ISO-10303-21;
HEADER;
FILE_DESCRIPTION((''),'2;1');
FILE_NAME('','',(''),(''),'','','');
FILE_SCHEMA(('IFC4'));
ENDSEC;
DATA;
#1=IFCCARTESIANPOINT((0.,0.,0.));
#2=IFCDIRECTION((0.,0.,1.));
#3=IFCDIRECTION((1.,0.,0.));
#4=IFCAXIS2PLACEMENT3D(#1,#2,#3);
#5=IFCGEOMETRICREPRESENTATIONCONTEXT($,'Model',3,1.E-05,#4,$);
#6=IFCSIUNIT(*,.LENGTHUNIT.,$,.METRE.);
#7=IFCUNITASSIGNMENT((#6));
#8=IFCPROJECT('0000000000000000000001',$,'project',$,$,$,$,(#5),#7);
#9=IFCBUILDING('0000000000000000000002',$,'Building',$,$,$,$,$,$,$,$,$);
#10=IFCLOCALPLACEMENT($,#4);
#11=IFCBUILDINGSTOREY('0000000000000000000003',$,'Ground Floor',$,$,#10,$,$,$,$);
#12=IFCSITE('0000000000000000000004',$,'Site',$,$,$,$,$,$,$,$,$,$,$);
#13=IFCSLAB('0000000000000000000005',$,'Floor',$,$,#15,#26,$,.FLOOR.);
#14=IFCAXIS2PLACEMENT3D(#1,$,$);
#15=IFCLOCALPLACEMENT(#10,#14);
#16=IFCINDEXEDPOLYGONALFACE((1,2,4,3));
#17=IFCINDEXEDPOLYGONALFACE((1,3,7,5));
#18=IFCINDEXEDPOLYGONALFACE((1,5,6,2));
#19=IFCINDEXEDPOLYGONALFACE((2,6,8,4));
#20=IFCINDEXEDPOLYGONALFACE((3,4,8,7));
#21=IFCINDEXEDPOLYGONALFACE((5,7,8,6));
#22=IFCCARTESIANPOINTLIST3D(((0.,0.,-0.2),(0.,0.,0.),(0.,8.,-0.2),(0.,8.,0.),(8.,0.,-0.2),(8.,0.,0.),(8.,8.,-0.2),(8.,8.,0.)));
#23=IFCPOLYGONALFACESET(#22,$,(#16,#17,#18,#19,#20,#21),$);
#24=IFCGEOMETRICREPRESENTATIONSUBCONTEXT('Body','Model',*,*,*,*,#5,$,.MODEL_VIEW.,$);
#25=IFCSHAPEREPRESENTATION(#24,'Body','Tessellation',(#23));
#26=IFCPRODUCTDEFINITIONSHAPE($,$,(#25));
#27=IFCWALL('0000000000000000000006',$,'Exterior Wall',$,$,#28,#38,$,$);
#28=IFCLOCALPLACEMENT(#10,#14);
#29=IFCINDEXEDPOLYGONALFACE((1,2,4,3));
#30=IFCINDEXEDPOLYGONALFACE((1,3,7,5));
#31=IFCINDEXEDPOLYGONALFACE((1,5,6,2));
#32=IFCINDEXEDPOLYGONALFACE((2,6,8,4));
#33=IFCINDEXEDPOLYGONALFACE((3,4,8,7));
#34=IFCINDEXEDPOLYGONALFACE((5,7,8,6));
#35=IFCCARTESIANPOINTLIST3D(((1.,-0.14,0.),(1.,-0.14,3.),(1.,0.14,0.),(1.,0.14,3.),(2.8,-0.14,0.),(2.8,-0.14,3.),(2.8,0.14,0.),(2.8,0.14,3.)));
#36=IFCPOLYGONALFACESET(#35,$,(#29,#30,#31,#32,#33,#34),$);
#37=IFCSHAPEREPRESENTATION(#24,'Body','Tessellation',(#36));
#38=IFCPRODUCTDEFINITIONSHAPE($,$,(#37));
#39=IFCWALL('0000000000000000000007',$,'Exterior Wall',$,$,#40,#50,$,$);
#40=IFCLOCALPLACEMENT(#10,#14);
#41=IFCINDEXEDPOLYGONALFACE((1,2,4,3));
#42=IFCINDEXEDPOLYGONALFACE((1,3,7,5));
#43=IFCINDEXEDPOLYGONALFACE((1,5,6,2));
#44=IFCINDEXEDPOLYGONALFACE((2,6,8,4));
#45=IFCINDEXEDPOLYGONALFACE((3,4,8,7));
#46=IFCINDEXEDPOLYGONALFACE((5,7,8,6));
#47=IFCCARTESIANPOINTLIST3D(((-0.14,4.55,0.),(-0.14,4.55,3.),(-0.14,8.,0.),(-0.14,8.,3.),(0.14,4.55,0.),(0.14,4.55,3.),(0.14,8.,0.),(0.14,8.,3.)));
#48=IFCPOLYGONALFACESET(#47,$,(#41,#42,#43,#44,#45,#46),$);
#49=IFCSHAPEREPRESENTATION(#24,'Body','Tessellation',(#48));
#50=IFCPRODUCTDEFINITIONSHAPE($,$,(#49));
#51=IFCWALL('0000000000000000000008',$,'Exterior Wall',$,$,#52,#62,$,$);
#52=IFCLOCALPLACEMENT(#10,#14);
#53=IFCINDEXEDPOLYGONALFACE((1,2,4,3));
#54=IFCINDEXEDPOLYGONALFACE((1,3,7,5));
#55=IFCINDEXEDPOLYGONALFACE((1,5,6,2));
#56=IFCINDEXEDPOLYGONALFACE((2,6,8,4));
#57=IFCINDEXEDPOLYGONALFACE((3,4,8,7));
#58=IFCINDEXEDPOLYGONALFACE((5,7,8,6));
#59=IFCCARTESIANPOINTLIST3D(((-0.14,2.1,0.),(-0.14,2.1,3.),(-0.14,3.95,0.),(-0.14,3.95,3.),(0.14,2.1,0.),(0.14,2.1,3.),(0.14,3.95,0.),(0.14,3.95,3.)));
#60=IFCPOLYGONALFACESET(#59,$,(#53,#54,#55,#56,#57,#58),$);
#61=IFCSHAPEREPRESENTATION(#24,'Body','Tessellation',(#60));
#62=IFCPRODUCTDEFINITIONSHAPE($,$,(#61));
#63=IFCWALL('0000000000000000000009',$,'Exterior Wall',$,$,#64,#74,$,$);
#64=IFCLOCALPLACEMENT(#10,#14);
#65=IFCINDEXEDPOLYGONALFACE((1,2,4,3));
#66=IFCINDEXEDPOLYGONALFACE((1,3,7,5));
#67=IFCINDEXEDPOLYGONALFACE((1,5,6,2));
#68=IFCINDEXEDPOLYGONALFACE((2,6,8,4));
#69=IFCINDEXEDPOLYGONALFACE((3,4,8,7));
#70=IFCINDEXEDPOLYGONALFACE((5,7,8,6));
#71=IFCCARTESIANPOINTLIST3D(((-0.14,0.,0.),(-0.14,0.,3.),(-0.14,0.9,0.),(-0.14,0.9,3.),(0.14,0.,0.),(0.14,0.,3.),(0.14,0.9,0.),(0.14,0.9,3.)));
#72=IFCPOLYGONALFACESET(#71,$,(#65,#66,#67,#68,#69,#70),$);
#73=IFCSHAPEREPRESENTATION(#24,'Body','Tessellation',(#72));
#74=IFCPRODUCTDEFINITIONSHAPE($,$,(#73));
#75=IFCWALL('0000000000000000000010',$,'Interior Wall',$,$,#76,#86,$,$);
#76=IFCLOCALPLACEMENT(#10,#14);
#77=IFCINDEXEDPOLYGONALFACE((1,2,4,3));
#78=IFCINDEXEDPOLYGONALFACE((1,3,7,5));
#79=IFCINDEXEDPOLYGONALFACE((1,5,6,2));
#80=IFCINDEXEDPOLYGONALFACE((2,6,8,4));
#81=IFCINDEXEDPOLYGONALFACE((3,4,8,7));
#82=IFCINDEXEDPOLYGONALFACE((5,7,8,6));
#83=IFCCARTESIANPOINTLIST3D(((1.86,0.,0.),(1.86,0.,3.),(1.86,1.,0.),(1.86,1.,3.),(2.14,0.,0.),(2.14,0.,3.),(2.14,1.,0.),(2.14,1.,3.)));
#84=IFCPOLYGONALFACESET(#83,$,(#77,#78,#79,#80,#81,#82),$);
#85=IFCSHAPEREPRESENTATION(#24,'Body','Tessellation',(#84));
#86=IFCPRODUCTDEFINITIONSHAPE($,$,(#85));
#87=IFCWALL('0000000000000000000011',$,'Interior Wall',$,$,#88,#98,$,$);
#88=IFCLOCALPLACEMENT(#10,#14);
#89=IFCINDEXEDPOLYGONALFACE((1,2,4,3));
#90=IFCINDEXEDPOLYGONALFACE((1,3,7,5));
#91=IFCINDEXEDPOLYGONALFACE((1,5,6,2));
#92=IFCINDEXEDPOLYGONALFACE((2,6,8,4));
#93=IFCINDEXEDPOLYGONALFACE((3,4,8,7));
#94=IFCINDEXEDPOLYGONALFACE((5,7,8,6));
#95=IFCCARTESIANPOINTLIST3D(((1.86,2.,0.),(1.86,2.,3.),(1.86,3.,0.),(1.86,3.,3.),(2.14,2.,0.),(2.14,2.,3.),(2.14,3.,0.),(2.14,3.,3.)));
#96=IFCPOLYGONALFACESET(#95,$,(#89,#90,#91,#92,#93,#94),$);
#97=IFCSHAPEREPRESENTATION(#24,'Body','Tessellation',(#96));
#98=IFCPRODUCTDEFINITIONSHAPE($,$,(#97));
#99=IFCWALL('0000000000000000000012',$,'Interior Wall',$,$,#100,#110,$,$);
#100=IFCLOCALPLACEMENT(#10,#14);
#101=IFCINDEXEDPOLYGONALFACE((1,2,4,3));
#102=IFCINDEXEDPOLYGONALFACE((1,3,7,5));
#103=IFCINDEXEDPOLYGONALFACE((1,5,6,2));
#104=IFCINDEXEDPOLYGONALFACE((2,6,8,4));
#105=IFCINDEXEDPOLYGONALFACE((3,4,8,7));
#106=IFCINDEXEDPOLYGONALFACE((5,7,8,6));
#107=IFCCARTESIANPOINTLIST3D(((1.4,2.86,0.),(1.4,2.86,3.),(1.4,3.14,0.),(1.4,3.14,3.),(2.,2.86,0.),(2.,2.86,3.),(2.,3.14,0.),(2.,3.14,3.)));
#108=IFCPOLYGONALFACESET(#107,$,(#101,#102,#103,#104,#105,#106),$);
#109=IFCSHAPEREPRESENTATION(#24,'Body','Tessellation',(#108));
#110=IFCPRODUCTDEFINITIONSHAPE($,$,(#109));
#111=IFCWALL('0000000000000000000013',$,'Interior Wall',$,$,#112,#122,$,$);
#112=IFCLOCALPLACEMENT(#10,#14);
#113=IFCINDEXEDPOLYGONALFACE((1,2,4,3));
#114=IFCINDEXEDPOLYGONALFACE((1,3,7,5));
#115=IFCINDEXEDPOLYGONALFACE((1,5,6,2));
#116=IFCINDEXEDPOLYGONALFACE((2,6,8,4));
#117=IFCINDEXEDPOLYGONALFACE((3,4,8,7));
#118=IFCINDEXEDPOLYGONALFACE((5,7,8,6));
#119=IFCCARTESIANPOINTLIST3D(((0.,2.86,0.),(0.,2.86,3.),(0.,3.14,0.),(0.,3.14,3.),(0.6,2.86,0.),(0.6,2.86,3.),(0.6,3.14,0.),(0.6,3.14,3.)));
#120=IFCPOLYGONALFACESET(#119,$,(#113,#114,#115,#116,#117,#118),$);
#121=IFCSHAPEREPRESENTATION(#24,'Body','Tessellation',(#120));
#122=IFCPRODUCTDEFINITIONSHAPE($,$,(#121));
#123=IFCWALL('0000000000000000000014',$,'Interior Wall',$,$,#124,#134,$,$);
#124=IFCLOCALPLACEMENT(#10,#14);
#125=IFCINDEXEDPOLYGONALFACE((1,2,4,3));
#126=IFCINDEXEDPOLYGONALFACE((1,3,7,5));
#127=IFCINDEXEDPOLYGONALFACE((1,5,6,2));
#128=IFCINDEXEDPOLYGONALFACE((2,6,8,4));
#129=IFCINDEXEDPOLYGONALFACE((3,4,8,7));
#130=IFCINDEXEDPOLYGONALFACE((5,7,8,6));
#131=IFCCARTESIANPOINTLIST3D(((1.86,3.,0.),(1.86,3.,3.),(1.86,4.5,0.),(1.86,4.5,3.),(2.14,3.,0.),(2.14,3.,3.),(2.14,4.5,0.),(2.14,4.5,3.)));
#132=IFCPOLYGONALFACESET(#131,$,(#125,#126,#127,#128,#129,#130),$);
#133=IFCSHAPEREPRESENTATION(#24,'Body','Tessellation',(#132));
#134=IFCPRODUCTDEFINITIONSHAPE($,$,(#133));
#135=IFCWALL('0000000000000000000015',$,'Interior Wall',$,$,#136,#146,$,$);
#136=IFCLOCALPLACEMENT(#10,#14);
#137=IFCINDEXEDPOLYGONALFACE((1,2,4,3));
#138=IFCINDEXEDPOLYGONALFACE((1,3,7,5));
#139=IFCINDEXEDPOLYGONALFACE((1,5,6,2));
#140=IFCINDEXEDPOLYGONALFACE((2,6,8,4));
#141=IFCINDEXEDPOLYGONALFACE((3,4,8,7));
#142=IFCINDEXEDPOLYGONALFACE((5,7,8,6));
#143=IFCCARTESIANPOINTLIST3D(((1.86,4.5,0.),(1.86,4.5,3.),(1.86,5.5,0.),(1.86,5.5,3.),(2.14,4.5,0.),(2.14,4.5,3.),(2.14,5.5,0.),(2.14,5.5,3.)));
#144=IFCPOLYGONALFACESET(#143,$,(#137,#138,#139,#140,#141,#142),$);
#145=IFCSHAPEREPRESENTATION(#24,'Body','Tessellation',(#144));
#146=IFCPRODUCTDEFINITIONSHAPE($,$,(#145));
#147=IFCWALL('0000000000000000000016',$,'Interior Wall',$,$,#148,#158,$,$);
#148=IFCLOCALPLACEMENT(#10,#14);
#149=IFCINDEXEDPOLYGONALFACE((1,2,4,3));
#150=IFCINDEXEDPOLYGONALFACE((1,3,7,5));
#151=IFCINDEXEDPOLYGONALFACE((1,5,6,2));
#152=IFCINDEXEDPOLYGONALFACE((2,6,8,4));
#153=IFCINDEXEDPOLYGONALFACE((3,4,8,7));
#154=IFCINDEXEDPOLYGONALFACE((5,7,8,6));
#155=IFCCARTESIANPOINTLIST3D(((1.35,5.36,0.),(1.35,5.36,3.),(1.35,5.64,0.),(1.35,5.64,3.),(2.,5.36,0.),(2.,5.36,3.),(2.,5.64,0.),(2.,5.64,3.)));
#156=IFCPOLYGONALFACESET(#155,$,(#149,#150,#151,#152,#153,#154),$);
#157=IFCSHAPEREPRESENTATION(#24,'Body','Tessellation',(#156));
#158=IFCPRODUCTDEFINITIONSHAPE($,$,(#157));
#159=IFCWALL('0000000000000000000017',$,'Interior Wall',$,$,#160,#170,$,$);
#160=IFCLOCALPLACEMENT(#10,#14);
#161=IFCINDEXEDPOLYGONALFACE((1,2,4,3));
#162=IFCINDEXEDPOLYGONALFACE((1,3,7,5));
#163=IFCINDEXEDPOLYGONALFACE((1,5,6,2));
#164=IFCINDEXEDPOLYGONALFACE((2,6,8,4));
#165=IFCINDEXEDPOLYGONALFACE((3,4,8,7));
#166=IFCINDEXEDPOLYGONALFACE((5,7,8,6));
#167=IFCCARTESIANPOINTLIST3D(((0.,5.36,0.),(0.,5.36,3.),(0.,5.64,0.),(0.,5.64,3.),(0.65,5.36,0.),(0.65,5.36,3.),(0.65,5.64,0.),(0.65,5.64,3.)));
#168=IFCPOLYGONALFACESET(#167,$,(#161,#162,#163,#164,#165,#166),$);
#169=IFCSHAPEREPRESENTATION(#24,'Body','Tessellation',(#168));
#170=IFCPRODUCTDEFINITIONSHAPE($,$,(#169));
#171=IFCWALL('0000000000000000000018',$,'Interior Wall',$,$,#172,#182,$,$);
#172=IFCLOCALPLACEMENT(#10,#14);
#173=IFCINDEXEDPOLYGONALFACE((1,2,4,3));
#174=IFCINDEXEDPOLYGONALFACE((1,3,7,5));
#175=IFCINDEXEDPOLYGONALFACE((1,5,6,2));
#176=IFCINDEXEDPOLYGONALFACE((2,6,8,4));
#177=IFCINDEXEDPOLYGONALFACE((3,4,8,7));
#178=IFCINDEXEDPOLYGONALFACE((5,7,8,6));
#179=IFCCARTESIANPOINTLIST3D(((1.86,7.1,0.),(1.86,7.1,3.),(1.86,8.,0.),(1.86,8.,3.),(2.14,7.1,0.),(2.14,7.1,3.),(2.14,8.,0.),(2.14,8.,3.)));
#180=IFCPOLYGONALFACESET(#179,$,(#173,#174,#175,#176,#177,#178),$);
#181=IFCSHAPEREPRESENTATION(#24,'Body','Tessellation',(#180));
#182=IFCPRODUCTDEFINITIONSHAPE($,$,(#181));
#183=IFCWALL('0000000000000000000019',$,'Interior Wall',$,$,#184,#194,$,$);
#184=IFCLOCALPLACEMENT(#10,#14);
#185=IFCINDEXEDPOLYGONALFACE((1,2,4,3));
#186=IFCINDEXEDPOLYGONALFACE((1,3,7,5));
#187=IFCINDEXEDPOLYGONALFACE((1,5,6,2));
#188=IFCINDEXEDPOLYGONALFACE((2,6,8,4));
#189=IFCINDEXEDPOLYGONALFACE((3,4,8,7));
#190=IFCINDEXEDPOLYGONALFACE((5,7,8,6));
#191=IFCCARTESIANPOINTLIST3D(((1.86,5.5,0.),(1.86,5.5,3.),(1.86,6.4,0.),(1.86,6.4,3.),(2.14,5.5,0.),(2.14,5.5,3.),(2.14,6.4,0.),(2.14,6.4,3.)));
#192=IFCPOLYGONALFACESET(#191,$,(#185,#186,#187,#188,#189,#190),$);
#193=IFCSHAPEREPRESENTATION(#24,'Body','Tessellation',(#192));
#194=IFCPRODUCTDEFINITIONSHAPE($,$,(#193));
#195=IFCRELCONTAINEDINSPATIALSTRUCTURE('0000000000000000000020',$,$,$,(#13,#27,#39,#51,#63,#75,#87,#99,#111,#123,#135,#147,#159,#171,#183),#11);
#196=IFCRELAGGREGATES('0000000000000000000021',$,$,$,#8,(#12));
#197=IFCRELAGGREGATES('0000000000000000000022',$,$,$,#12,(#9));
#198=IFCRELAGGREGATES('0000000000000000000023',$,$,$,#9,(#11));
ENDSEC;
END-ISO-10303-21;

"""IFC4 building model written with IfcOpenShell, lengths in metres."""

from ifc_helpers import new_model, si_unit, frame, origin_with_axes, place, context, subcontext, project, spatial, indexed_curve, outline, extrude, element, save


model = new_model("IFC4")

# Units and contexts
model_context = context("Model", 3, precision=1e-05, world=origin_with_axes())
body_context = subcontext(model_context, "Body", "Model", "MODEL_VIEW")
ifc_project = project(units=[si_unit("LENGTHUNIT", "METRE")], contexts=[model_context])

# Site, building, storey
site = spatial("IfcSite", under=ifc_project, Name="Site")
building = spatial("IfcBuilding", under=site, Name="Building")
storey_placement = place(None, origin_with_axes())
storey = spatial("IfcBuildingStorey", under=building, at=storey_placement, Name="Ground Floor")

# Slab
slab_placement = place(storey_placement, frame((0.0, 0.0, -0.2), z_axis=(0.0, 0.0, 1.0), x_axis=(1.0, 0.0, 0.0)))
element("IfcSlab", 1, at=slab_placement, inside=storey, Name="Floor", PredefinedType="FLOOR", context=body_context, shape_type="SweptSolid", body=[
    extrude(outline(indexed_curve([(0.0, 0.0), (8.0, 0.0), (8.0, 8.0), (0.0, 8.0)])), None, (0.0, 0.0, 1.0), 0.2),
])

# Walls
wall_1_placement = place(storey_placement, frame((1.0, 0.0, 0.0), z_axis=(0.0, 0.0, 1.0), x_axis=(1.0, 0.0, 0.0)))
element("IfcWall", 2, at=wall_1_placement, inside=storey, Name="Exterior Wall", context=body_context, shape_type="SweptSolid", body=[
    extrude(outline(indexed_curve([(0.0, 0.0), (0.0, 0.28), (1.8, 0.28), (1.8, 0.0), (0.0, 0.0)], self_intersect=False)), frame((0.0, -0.14, 0.0), z_axis=(0.0, 0.0, 1.0), x_axis=(1.0, 0.0, 0.0)), (0.0, 0.0, 1.0), 3.0),
])
wall_2_placement = place(storey_placement, frame((0.0, 8.0, 0.0), z_axis=(0.0, 0.0, 1.0), x_axis=(0.0, -1.0, 0.0)))
element("IfcWall", 3, at=wall_2_placement, inside=storey, Name="Exterior Wall", context=body_context, shape_type="SweptSolid", body=[
    extrude(outline(indexed_curve([(0.0, 0.0), (0.0, 0.28), (3.45, 0.28), (3.45, 0.0), (0.0, 0.0)], self_intersect=False)), frame((0.0, -0.14, 0.0), z_axis=(0.0, 0.0, 1.0), x_axis=(1.0, 0.0, 0.0)), (0.0, 0.0, 1.0), 3.0),
])
wall_3_placement = place(storey_placement, frame((0.0, 3.95, 0.0), z_axis=(0.0, 0.0, 1.0), x_axis=(0.0, -1.0, 0.0)))
element("IfcWall", 4, at=wall_3_placement, inside=storey, Name="Exterior Wall", context=body_context, shape_type="SweptSolid", body=[
    extrude(outline(indexed_curve([(0.0, 0.0), (0.0, 0.28), (1.85, 0.28), (1.85, 0.0), (0.0, 0.0)], self_intersect=False)), frame((0.0, -0.14, 0.0), z_axis=(0.0, 0.0, 1.0), x_axis=(1.0, 0.0, 0.0)), (0.0, 0.0, 1.0), 3.0),
])
wall_4_placement = place(storey_placement, frame((0.0, 0.9, 0.0), z_axis=(0.0, 0.0, 1.0), x_axis=(0.0, -1.0, 0.0)))
element("IfcWall", 5, at=wall_4_placement, inside=storey, Name="Exterior Wall", context=body_context, shape_type="SweptSolid", body=[
    extrude(outline(indexed_curve([(0.0, 0.0), (0.0, 0.28), (0.9, 0.28), (0.9, 0.0), (0.0, 0.0)], self_intersect=False)), frame((0.0, -0.14, 0.0), z_axis=(0.0, 0.0, 1.0), x_axis=(1.0, 0.0, 0.0)), (0.0, 0.0, 1.0), 3.0),
])
for number, where, z_axis, x_axis, name in (
    (6, (2.0, 0.0, 0.0), (0.0, 0.0, 1.0), (0.0, 1.0, 0.0), "Interior Wall"),
    (7, (2.0, 2.0, 0.0), (0.0, 0.0, 1.0), (0.0, 1.0, 0.0), "Interior Wall"),
):
    element("IfcWall", number, at=place(storey_placement, frame(where, z_axis=z_axis, x_axis=x_axis)), inside=storey, Name=name, context=body_context, shape_type="SweptSolid", body=[
        extrude(outline(indexed_curve([(0.0, 0.0), (0.0, 0.28), (1.0, 0.28), (1.0, 0.0), (0.0, 0.0)], self_intersect=False)), frame((0.0, -0.14, 0.0), z_axis=(0.0, 0.0, 1.0), x_axis=(1.0, 0.0, 0.0)), (0.0, 0.0, 1.0), 3.0),
    ])
for number, where, z_axis, x_axis, name in (
    (8, (2.0, 3.0, 0.0), (0.0, 0.0, 1.0), (-1.0, 0.0, 0.0), "Interior Wall"),
    (9, (0.6, 3.0, 0.0), (0.0, 0.0, 1.0), (-1.0, 0.0, 0.0), "Interior Wall"),
):
    element("IfcWall", number, at=place(storey_placement, frame(where, z_axis=z_axis, x_axis=x_axis)), inside=storey, Name=name, context=body_context, shape_type="SweptSolid", body=[
        extrude(outline(indexed_curve([(0.0, 0.0), (0.0, 0.28), (0.6, 0.28), (0.6, 0.0), (0.0, 0.0)], self_intersect=False)), frame((0.0, -0.14, 0.0), z_axis=(0.0, 0.0, 1.0), x_axis=(1.0, 0.0, 0.0)), (0.0, 0.0, 1.0), 3.0),
    ])
wall_5_placement = place(storey_placement, frame((2.0, 4.5, 0.0), z_axis=(0.0, 0.0, 1.0), x_axis=(0.0, -1.0, 0.0)))
element("IfcWall", 10, at=wall_5_placement, inside=storey, Name="Interior Wall", context=body_context, shape_type="SweptSolid", body=[
    extrude(outline(indexed_curve([(0.0, 0.0), (0.0, 0.28), (1.5, 0.28), (1.5, 0.0), (0.0, 0.0)], self_intersect=False)), frame((0.0, -0.14, 0.0), z_axis=(0.0, 0.0, 1.0), x_axis=(1.0, 0.0, 0.0)), (0.0, 0.0, 1.0), 3.0),
])
wall_6_placement = place(storey_placement, frame((2.0, 4.5, 0.0), z_axis=(0.0, 0.0, 1.0), x_axis=(0.0, 1.0, 0.0)))
element("IfcWall", 11, at=wall_6_placement, inside=storey, Name="Interior Wall", context=body_context, shape_type="SweptSolid", body=[
    extrude(outline(indexed_curve([(0.0, 0.0), (0.0, 0.28), (1.0, 0.28), (1.0, 0.0), (0.0, 0.0)], self_intersect=False)), frame((0.0, -0.14, 0.0), z_axis=(0.0, 0.0, 1.0), x_axis=(1.0, 0.0, 0.0)), (0.0, 0.0, 1.0), 3.0),
])
for number, where, z_axis, x_axis, name in (
    (12, (2.0, 5.5, 0.0), (0.0, 0.0, 1.0), (-1.0, 0.0, 0.0), "Interior Wall"),
    (13, (0.65, 5.5, 0.0), (0.0, 0.0, 1.0), (-1.0, 0.0, 0.0), "Interior Wall"),
):
    element("IfcWall", number, at=place(storey_placement, frame(where, z_axis=z_axis, x_axis=x_axis)), inside=storey, Name=name, context=body_context, shape_type="SweptSolid", body=[
        extrude(outline(indexed_curve([(0.0, 0.0), (0.0, 0.28), (0.65, 0.28), (0.65, 0.0), (0.0, 0.0)], self_intersect=False)), frame((0.0, -0.14, 0.0), z_axis=(0.0, 0.0, 1.0), x_axis=(1.0, 0.0, 0.0)), (0.0, 0.0, 1.0), 3.0),
    ])
for number, where, z_axis, x_axis, name in (
    (14, (2.0, 8.0, 0.0), (0.0, 0.0, 1.0), (0.0, -1.0, 0.0), "Interior Wall"),
    (15, (2.0, 6.4, 0.0), (0.0, 0.0, 1.0), (0.0, -1.0, 0.0), "Interior Wall"),
):
    element("IfcWall", number, at=place(storey_placement, frame(where, z_axis=z_axis, x_axis=x_axis)), inside=storey, Name=name, context=body_context, shape_type="SweptSolid", body=[
        extrude(outline(indexed_curve([(0.0, 0.0), (0.0, 0.28), (0.9, 0.28), (0.9, 0.0), (0.0, 0.0)], self_intersect=False)), frame((0.0, -0.14, 0.0), z_axis=(0.0, 0.0, 1.0), x_axis=(1.0, 0.0, 0.0)), (0.0, 0.0, 1.0), 3.0),
    ])

save(model, "model.ifc")
